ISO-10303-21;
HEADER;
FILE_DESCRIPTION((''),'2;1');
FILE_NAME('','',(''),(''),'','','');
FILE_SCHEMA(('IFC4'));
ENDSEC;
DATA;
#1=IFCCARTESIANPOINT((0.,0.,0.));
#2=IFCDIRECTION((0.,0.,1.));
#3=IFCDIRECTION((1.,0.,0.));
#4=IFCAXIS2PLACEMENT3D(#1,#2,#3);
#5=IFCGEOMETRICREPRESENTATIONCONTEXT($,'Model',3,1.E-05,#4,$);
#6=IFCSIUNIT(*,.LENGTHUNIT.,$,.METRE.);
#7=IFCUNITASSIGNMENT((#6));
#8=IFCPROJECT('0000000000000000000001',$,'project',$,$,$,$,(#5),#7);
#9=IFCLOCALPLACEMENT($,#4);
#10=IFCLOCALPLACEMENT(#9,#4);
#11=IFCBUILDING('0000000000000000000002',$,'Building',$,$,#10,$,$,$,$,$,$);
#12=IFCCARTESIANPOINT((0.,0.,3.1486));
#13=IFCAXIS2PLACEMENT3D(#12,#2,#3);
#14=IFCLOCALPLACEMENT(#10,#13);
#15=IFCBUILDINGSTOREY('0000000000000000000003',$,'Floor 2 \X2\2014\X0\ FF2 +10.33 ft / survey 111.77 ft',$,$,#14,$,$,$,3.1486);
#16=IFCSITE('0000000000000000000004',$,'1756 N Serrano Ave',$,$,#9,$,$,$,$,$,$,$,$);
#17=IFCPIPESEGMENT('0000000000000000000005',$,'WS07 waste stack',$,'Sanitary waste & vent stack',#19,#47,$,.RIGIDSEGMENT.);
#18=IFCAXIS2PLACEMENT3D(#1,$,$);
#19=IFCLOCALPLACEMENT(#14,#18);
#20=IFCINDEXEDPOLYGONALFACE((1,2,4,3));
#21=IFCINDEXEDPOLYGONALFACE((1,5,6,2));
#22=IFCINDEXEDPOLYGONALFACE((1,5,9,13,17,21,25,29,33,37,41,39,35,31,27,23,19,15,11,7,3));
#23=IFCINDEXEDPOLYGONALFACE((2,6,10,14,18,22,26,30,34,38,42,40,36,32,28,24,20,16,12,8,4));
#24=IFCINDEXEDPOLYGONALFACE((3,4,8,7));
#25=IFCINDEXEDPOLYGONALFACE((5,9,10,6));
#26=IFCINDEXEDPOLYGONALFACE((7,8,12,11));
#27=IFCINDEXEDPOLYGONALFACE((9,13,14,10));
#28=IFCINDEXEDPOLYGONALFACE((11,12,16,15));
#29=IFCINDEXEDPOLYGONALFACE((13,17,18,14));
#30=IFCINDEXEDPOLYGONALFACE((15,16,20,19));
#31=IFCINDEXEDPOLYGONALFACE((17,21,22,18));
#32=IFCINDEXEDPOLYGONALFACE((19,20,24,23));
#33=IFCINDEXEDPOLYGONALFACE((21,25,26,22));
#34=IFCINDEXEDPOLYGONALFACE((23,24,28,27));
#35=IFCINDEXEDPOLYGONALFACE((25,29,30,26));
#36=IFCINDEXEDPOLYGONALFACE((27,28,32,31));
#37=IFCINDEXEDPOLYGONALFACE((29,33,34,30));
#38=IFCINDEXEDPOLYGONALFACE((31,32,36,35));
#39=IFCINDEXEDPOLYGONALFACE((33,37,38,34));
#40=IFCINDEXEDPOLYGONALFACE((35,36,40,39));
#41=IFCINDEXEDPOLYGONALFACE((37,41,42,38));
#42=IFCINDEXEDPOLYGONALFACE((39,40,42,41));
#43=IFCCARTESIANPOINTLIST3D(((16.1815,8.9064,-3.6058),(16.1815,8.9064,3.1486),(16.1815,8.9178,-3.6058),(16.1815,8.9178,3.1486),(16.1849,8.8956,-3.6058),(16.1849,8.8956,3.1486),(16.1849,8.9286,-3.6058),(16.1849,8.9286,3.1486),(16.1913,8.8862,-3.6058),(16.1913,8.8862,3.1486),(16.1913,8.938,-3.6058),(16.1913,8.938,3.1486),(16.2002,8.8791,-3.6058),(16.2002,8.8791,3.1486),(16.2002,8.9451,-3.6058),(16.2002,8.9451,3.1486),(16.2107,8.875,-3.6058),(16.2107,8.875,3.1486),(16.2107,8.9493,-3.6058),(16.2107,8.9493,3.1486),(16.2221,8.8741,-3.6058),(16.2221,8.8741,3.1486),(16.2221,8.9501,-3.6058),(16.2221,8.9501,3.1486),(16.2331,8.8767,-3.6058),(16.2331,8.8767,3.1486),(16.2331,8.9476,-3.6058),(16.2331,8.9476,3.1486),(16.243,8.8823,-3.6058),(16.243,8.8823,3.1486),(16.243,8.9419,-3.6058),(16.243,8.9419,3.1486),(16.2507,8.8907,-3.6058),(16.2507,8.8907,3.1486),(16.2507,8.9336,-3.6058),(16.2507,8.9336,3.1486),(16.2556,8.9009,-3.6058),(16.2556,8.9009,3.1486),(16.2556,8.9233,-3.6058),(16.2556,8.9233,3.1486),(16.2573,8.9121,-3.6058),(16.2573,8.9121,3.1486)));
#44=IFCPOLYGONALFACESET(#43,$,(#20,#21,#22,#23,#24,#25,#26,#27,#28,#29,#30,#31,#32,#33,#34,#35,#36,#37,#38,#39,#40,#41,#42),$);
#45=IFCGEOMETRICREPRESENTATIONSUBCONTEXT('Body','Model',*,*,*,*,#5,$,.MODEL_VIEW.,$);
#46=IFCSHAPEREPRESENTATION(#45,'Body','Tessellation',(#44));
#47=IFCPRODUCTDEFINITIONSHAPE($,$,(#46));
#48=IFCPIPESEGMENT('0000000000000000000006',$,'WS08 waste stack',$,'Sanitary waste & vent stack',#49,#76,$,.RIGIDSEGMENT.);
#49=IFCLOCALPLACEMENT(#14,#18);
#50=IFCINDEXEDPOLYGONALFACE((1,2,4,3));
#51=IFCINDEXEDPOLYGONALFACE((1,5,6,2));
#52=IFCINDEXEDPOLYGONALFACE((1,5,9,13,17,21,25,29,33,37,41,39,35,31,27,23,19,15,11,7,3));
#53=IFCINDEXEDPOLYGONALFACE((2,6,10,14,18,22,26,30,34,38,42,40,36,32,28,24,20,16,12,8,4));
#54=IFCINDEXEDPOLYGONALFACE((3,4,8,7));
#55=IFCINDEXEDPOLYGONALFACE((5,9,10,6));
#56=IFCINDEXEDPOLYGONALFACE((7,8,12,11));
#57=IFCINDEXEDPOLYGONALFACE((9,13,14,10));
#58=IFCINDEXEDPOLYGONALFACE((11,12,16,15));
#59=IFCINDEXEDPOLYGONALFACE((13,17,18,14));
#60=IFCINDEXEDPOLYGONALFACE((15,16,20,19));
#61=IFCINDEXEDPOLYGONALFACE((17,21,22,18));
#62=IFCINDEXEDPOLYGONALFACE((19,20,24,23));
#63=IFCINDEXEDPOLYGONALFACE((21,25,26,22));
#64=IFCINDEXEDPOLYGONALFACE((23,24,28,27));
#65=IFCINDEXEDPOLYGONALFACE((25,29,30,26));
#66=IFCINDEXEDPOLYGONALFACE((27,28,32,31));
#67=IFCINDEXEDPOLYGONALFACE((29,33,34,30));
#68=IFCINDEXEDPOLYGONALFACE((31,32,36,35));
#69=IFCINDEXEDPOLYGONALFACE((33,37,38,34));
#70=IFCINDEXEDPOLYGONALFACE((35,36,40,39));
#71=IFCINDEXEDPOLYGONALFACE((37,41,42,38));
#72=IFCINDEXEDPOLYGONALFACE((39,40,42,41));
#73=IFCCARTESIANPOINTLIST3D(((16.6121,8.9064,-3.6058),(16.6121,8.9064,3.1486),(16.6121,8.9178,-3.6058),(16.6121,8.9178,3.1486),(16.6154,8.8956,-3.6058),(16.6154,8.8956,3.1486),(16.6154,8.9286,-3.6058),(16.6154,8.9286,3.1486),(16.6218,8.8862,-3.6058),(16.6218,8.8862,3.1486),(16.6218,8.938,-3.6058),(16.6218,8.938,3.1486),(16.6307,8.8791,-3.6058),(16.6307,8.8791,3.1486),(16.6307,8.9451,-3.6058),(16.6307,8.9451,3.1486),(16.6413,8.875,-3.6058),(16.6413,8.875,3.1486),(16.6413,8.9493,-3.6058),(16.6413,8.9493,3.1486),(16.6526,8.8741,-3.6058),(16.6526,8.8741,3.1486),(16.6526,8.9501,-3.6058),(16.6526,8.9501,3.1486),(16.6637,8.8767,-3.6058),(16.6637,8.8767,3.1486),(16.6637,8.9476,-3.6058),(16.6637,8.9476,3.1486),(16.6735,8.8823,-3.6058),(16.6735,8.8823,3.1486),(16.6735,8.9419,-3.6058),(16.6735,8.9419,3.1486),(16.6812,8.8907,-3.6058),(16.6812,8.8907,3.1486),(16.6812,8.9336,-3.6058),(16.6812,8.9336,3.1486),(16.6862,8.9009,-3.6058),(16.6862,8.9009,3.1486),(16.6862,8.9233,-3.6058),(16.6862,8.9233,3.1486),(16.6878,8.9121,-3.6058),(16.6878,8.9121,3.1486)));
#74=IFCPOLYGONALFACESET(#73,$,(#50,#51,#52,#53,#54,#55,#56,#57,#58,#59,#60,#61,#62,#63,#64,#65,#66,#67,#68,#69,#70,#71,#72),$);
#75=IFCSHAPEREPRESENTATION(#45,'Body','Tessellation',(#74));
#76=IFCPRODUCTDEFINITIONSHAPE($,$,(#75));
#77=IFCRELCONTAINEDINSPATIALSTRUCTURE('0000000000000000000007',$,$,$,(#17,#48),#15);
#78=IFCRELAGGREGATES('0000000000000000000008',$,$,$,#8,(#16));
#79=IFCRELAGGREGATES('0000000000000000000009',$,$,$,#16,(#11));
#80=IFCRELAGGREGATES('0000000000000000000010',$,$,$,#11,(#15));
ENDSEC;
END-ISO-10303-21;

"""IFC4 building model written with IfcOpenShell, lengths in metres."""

from ifc_helpers import new_model, entity, si_unit, frame, origin_with_axes, place, context, subcontext, project, spatial, element, save


model = new_model("IFC4")

# Units and contexts
model_context = context("Model", 3, precision=1e-05, world=origin_with_axes())
body_context = subcontext(model_context, "Body", "Model", "MODEL_VIEW")
ifc_project = project(units=[si_unit("LENGTHUNIT", "METRE")], contexts=[model_context])

# Site, building, storey
site_placement = place(None, origin_with_axes())
site = spatial("IfcSite", under=ifc_project, at=site_placement, Name="1756 N Serrano Ave")
building_placement = place(site_placement, origin_with_axes())
building = spatial("IfcBuilding", under=site, at=building_placement, Name="Building")
storey_placement = place(building_placement, frame((0.0, 0.0, 3.1486), z_axis=(0.0, 0.0, 1.0), x_axis=(1.0, 0.0, 0.0)))
storey = spatial("IfcBuildingStorey", under=building, at=storey_placement, Name="Floor 2 — FF2 +10.33 ft / survey 111.77 ft", Elevation=3.1486)

# Pipe segments
pipe_segment_1_placement = place(storey_placement, frame((0.0, 0.0, -3.1486), z_axis=(0.0, 0.0, 1.0), x_axis=(1.0, 0.0, 0.0)))
element("IfcPipeSegment", 1, at=pipe_segment_1_placement, inside=storey, Name="WS07 waste stack", ObjectType="Sanitary waste & vent stack", PredefinedType="RIGIDSEGMENT", context=body_context, shape_type="AdvancedSweptSolid", body=[
    entity("IfcSweptDiskSolid", entity("IfcPolyline", [entity("IfcCartesianPoint", [16.2192, 8.9121, -0.4572]), entity("IfcCartesianPoint", [16.2192, 8.9121, 6.2972])]), 0.0381),
])
pipe_segment_2_placement = place(storey_placement, frame((0.0, 0.0, -3.1486), z_axis=(0.0, 0.0, 1.0), x_axis=(1.0, 0.0, 0.0)))
element("IfcPipeSegment", 2, at=pipe_segment_2_placement, inside=storey, Name="WS08 waste stack", ObjectType="Sanitary waste & vent stack", PredefinedType="RIGIDSEGMENT", context=body_context, shape_type="AdvancedSweptSolid", body=[
    entity("IfcSweptDiskSolid", entity("IfcPolyline", [entity("IfcCartesianPoint", [16.6497, 8.9121, -0.4572]), entity("IfcCartesianPoint", [16.6497, 8.9121, 6.2972])]), 0.0381),
])

save(model, "model.ifc")
